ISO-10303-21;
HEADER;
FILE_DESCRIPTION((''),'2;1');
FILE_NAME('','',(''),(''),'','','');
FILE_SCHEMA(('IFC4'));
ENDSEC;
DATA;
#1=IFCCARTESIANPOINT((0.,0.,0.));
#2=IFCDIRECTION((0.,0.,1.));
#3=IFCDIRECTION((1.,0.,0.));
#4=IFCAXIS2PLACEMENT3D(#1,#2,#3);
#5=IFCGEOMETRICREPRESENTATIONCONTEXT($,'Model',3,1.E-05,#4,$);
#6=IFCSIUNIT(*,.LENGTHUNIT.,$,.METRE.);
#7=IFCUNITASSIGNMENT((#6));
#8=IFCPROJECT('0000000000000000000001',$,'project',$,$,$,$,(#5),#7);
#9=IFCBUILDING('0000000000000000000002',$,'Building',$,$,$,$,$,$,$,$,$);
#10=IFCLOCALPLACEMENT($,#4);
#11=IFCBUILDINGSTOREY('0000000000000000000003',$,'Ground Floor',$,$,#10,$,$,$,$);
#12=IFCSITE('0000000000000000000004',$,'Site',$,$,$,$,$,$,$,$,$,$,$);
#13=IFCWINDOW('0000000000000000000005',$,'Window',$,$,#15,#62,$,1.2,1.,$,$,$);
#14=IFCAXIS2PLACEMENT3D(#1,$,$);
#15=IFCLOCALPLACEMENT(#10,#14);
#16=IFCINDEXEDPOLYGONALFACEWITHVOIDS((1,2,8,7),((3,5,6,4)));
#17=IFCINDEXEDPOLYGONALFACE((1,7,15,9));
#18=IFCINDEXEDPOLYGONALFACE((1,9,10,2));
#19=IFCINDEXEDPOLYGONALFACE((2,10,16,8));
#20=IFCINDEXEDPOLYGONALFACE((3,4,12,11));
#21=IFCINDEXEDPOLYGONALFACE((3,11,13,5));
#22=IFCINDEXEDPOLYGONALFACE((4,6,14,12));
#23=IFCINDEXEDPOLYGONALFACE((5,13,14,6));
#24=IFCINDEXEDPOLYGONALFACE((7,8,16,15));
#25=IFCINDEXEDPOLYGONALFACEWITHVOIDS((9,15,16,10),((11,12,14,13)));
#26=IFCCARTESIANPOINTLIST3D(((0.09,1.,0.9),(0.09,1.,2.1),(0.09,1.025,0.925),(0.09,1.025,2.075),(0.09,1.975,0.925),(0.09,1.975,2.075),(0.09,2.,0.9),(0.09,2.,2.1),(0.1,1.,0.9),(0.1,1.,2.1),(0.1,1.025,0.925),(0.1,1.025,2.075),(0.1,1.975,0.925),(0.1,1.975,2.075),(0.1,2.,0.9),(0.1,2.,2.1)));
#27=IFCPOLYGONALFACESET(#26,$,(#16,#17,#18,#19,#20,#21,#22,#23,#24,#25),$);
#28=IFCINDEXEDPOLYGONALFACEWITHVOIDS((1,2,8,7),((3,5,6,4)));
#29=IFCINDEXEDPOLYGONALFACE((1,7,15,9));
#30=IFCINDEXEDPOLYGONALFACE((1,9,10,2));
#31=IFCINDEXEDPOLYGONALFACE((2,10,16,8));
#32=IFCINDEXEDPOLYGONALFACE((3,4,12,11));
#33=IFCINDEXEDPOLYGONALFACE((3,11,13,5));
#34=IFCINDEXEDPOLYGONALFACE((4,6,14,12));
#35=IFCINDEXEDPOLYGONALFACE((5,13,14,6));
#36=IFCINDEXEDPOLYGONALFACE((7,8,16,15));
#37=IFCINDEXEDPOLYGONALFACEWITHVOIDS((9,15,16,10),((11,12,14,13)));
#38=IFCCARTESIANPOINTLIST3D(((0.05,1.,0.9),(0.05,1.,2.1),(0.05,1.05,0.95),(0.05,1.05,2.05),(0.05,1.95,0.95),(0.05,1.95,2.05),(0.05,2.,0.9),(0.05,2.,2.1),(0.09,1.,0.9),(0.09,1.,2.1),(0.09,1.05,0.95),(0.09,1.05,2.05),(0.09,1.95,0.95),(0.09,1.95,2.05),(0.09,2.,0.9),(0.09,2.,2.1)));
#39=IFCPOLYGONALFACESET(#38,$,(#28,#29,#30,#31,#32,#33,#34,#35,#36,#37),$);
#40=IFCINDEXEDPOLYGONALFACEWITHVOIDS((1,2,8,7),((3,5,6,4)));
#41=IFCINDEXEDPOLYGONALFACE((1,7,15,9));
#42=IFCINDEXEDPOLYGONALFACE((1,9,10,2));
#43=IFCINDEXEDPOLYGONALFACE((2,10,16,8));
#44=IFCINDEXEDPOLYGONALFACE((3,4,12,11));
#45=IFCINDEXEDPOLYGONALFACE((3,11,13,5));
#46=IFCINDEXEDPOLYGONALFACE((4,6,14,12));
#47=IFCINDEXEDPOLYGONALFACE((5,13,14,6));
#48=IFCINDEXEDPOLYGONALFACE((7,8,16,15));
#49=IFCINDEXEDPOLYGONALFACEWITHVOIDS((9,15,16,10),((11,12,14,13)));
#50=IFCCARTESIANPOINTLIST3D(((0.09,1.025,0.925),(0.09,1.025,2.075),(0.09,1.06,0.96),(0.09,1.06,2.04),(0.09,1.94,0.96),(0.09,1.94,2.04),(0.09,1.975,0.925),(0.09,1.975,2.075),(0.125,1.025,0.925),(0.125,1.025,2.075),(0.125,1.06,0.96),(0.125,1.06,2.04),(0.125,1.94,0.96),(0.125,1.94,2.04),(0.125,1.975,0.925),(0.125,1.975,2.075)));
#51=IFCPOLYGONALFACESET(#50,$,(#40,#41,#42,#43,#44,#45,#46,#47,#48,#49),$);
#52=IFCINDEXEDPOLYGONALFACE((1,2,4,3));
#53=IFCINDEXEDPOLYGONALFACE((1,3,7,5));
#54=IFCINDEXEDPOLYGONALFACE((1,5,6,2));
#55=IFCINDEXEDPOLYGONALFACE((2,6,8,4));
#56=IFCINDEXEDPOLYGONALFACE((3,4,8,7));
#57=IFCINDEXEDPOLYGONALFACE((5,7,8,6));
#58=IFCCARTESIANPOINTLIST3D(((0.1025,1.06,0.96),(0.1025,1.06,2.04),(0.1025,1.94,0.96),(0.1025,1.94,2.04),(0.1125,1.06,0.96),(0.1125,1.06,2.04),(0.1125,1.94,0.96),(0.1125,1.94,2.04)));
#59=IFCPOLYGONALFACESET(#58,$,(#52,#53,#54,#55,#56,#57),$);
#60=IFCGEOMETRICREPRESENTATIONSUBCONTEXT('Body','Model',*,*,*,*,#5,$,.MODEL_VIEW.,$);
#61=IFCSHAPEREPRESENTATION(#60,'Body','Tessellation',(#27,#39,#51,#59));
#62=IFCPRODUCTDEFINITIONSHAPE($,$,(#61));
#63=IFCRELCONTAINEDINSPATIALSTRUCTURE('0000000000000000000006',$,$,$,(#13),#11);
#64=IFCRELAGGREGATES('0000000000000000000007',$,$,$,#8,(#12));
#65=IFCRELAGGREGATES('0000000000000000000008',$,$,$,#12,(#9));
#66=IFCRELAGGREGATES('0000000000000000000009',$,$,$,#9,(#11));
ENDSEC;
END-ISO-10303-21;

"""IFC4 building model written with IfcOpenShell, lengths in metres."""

from ifc_helpers import new_model, si_unit, frame, origin_with_axes, place, context, subcontext, project, spatial, line, indexed_curve, outline, extrude, element, save


model = new_model("IFC4")

# Units and contexts
model_context = context("Model", 3, precision=1e-05, world=origin_with_axes())
body_context = subcontext(model_context, "Body", "Model", "MODEL_VIEW")
ifc_project = project(units=[si_unit("LENGTHUNIT", "METRE")], contexts=[model_context])

# Site, building, storey
site = spatial("IfcSite", under=ifc_project, Name="Site")
building = spatial("IfcBuilding", under=site, Name="Building")
storey_placement = place(None, origin_with_axes())
storey = spatial("IfcBuildingStorey", under=building, at=storey_placement, Name="Ground Floor")

# Window
window_1_placement = place(storey_placement, frame((0.0, 2.0, 0.9), z_axis=(0.0, 0.0, 1.0), x_axis=(0.0, -1.0, 0.0)))
element("IfcWindow", 1, at=window_1_placement, inside=storey, Name="Window", OverallHeight=1.2, OverallWidth=1.0, context=body_context, shape_type="SweptSolid", body=[
    extrude(outline(indexed_curve([(0.0, 0.0), (1.0, 0.0), (1.0, 1.2), (0.0, 1.2)], segments=[line(1, 2, 3, 4, 1)]), holes=[indexed_curve([(0.025, 0.025), (0.975, 0.025), (0.975, 1.175), (0.025, 1.175)], segments=[line(1, 2, 3, 4, 1)])]), frame((0.0, 0.09, 0.0), z_axis=(0.0, -1.0, 0.0), x_axis=(1.0, 0.0, 0.0)), (0.0, 0.0, -1.0), 0.01),
    extrude(outline(indexed_curve([(0.0, 0.0), (1.0, 0.0), (1.0, 1.2), (0.0, 1.2)], segments=[line(1, 2, 3, 4, 1)]), holes=[indexed_curve([(0.05, 0.05), (0.95, 0.05), (0.95, 1.15), (0.05, 1.15)], segments=[line(1, 2, 3, 4, 1)])]), frame((0.0, 0.05, 0.0), z_axis=(0.0, -1.0, 0.0), x_axis=(1.0, 0.0, 0.0)), (0.0, 0.0, -1.0), 0.04),
    extrude(outline(indexed_curve([(0.0, 0.0), (0.95, 0.0), (0.95, 1.15), (0.0, 1.15)], segments=[line(1, 2, 3, 4, 1)]), holes=[indexed_curve([(0.035, 0.035), (0.915, 0.035), (0.915, 1.115), (0.035, 1.115)], segments=[line(1, 2, 3, 4, 1)])]), frame((0.025, 0.09, 0.025), z_axis=(0.0, -1.0, 0.0), x_axis=(1.0, 0.0, 0.0)), (0.0, 0.0, -1.0), 0.035),
    extrude(outline(indexed_curve([(0.035, 0.035), (0.915, 0.035), (0.915, 1.115), (0.035, 1.115)], segments=[line(1, 2, 3, 4, 1)])), frame((0.025, 0.1025, 0.025), z_axis=(0.0, -1.0, 0.0), x_axis=(1.0, 0.0, 0.0)), (0.0, 0.0, -1.0), 0.01),
])

save(model, "model.ifc")
